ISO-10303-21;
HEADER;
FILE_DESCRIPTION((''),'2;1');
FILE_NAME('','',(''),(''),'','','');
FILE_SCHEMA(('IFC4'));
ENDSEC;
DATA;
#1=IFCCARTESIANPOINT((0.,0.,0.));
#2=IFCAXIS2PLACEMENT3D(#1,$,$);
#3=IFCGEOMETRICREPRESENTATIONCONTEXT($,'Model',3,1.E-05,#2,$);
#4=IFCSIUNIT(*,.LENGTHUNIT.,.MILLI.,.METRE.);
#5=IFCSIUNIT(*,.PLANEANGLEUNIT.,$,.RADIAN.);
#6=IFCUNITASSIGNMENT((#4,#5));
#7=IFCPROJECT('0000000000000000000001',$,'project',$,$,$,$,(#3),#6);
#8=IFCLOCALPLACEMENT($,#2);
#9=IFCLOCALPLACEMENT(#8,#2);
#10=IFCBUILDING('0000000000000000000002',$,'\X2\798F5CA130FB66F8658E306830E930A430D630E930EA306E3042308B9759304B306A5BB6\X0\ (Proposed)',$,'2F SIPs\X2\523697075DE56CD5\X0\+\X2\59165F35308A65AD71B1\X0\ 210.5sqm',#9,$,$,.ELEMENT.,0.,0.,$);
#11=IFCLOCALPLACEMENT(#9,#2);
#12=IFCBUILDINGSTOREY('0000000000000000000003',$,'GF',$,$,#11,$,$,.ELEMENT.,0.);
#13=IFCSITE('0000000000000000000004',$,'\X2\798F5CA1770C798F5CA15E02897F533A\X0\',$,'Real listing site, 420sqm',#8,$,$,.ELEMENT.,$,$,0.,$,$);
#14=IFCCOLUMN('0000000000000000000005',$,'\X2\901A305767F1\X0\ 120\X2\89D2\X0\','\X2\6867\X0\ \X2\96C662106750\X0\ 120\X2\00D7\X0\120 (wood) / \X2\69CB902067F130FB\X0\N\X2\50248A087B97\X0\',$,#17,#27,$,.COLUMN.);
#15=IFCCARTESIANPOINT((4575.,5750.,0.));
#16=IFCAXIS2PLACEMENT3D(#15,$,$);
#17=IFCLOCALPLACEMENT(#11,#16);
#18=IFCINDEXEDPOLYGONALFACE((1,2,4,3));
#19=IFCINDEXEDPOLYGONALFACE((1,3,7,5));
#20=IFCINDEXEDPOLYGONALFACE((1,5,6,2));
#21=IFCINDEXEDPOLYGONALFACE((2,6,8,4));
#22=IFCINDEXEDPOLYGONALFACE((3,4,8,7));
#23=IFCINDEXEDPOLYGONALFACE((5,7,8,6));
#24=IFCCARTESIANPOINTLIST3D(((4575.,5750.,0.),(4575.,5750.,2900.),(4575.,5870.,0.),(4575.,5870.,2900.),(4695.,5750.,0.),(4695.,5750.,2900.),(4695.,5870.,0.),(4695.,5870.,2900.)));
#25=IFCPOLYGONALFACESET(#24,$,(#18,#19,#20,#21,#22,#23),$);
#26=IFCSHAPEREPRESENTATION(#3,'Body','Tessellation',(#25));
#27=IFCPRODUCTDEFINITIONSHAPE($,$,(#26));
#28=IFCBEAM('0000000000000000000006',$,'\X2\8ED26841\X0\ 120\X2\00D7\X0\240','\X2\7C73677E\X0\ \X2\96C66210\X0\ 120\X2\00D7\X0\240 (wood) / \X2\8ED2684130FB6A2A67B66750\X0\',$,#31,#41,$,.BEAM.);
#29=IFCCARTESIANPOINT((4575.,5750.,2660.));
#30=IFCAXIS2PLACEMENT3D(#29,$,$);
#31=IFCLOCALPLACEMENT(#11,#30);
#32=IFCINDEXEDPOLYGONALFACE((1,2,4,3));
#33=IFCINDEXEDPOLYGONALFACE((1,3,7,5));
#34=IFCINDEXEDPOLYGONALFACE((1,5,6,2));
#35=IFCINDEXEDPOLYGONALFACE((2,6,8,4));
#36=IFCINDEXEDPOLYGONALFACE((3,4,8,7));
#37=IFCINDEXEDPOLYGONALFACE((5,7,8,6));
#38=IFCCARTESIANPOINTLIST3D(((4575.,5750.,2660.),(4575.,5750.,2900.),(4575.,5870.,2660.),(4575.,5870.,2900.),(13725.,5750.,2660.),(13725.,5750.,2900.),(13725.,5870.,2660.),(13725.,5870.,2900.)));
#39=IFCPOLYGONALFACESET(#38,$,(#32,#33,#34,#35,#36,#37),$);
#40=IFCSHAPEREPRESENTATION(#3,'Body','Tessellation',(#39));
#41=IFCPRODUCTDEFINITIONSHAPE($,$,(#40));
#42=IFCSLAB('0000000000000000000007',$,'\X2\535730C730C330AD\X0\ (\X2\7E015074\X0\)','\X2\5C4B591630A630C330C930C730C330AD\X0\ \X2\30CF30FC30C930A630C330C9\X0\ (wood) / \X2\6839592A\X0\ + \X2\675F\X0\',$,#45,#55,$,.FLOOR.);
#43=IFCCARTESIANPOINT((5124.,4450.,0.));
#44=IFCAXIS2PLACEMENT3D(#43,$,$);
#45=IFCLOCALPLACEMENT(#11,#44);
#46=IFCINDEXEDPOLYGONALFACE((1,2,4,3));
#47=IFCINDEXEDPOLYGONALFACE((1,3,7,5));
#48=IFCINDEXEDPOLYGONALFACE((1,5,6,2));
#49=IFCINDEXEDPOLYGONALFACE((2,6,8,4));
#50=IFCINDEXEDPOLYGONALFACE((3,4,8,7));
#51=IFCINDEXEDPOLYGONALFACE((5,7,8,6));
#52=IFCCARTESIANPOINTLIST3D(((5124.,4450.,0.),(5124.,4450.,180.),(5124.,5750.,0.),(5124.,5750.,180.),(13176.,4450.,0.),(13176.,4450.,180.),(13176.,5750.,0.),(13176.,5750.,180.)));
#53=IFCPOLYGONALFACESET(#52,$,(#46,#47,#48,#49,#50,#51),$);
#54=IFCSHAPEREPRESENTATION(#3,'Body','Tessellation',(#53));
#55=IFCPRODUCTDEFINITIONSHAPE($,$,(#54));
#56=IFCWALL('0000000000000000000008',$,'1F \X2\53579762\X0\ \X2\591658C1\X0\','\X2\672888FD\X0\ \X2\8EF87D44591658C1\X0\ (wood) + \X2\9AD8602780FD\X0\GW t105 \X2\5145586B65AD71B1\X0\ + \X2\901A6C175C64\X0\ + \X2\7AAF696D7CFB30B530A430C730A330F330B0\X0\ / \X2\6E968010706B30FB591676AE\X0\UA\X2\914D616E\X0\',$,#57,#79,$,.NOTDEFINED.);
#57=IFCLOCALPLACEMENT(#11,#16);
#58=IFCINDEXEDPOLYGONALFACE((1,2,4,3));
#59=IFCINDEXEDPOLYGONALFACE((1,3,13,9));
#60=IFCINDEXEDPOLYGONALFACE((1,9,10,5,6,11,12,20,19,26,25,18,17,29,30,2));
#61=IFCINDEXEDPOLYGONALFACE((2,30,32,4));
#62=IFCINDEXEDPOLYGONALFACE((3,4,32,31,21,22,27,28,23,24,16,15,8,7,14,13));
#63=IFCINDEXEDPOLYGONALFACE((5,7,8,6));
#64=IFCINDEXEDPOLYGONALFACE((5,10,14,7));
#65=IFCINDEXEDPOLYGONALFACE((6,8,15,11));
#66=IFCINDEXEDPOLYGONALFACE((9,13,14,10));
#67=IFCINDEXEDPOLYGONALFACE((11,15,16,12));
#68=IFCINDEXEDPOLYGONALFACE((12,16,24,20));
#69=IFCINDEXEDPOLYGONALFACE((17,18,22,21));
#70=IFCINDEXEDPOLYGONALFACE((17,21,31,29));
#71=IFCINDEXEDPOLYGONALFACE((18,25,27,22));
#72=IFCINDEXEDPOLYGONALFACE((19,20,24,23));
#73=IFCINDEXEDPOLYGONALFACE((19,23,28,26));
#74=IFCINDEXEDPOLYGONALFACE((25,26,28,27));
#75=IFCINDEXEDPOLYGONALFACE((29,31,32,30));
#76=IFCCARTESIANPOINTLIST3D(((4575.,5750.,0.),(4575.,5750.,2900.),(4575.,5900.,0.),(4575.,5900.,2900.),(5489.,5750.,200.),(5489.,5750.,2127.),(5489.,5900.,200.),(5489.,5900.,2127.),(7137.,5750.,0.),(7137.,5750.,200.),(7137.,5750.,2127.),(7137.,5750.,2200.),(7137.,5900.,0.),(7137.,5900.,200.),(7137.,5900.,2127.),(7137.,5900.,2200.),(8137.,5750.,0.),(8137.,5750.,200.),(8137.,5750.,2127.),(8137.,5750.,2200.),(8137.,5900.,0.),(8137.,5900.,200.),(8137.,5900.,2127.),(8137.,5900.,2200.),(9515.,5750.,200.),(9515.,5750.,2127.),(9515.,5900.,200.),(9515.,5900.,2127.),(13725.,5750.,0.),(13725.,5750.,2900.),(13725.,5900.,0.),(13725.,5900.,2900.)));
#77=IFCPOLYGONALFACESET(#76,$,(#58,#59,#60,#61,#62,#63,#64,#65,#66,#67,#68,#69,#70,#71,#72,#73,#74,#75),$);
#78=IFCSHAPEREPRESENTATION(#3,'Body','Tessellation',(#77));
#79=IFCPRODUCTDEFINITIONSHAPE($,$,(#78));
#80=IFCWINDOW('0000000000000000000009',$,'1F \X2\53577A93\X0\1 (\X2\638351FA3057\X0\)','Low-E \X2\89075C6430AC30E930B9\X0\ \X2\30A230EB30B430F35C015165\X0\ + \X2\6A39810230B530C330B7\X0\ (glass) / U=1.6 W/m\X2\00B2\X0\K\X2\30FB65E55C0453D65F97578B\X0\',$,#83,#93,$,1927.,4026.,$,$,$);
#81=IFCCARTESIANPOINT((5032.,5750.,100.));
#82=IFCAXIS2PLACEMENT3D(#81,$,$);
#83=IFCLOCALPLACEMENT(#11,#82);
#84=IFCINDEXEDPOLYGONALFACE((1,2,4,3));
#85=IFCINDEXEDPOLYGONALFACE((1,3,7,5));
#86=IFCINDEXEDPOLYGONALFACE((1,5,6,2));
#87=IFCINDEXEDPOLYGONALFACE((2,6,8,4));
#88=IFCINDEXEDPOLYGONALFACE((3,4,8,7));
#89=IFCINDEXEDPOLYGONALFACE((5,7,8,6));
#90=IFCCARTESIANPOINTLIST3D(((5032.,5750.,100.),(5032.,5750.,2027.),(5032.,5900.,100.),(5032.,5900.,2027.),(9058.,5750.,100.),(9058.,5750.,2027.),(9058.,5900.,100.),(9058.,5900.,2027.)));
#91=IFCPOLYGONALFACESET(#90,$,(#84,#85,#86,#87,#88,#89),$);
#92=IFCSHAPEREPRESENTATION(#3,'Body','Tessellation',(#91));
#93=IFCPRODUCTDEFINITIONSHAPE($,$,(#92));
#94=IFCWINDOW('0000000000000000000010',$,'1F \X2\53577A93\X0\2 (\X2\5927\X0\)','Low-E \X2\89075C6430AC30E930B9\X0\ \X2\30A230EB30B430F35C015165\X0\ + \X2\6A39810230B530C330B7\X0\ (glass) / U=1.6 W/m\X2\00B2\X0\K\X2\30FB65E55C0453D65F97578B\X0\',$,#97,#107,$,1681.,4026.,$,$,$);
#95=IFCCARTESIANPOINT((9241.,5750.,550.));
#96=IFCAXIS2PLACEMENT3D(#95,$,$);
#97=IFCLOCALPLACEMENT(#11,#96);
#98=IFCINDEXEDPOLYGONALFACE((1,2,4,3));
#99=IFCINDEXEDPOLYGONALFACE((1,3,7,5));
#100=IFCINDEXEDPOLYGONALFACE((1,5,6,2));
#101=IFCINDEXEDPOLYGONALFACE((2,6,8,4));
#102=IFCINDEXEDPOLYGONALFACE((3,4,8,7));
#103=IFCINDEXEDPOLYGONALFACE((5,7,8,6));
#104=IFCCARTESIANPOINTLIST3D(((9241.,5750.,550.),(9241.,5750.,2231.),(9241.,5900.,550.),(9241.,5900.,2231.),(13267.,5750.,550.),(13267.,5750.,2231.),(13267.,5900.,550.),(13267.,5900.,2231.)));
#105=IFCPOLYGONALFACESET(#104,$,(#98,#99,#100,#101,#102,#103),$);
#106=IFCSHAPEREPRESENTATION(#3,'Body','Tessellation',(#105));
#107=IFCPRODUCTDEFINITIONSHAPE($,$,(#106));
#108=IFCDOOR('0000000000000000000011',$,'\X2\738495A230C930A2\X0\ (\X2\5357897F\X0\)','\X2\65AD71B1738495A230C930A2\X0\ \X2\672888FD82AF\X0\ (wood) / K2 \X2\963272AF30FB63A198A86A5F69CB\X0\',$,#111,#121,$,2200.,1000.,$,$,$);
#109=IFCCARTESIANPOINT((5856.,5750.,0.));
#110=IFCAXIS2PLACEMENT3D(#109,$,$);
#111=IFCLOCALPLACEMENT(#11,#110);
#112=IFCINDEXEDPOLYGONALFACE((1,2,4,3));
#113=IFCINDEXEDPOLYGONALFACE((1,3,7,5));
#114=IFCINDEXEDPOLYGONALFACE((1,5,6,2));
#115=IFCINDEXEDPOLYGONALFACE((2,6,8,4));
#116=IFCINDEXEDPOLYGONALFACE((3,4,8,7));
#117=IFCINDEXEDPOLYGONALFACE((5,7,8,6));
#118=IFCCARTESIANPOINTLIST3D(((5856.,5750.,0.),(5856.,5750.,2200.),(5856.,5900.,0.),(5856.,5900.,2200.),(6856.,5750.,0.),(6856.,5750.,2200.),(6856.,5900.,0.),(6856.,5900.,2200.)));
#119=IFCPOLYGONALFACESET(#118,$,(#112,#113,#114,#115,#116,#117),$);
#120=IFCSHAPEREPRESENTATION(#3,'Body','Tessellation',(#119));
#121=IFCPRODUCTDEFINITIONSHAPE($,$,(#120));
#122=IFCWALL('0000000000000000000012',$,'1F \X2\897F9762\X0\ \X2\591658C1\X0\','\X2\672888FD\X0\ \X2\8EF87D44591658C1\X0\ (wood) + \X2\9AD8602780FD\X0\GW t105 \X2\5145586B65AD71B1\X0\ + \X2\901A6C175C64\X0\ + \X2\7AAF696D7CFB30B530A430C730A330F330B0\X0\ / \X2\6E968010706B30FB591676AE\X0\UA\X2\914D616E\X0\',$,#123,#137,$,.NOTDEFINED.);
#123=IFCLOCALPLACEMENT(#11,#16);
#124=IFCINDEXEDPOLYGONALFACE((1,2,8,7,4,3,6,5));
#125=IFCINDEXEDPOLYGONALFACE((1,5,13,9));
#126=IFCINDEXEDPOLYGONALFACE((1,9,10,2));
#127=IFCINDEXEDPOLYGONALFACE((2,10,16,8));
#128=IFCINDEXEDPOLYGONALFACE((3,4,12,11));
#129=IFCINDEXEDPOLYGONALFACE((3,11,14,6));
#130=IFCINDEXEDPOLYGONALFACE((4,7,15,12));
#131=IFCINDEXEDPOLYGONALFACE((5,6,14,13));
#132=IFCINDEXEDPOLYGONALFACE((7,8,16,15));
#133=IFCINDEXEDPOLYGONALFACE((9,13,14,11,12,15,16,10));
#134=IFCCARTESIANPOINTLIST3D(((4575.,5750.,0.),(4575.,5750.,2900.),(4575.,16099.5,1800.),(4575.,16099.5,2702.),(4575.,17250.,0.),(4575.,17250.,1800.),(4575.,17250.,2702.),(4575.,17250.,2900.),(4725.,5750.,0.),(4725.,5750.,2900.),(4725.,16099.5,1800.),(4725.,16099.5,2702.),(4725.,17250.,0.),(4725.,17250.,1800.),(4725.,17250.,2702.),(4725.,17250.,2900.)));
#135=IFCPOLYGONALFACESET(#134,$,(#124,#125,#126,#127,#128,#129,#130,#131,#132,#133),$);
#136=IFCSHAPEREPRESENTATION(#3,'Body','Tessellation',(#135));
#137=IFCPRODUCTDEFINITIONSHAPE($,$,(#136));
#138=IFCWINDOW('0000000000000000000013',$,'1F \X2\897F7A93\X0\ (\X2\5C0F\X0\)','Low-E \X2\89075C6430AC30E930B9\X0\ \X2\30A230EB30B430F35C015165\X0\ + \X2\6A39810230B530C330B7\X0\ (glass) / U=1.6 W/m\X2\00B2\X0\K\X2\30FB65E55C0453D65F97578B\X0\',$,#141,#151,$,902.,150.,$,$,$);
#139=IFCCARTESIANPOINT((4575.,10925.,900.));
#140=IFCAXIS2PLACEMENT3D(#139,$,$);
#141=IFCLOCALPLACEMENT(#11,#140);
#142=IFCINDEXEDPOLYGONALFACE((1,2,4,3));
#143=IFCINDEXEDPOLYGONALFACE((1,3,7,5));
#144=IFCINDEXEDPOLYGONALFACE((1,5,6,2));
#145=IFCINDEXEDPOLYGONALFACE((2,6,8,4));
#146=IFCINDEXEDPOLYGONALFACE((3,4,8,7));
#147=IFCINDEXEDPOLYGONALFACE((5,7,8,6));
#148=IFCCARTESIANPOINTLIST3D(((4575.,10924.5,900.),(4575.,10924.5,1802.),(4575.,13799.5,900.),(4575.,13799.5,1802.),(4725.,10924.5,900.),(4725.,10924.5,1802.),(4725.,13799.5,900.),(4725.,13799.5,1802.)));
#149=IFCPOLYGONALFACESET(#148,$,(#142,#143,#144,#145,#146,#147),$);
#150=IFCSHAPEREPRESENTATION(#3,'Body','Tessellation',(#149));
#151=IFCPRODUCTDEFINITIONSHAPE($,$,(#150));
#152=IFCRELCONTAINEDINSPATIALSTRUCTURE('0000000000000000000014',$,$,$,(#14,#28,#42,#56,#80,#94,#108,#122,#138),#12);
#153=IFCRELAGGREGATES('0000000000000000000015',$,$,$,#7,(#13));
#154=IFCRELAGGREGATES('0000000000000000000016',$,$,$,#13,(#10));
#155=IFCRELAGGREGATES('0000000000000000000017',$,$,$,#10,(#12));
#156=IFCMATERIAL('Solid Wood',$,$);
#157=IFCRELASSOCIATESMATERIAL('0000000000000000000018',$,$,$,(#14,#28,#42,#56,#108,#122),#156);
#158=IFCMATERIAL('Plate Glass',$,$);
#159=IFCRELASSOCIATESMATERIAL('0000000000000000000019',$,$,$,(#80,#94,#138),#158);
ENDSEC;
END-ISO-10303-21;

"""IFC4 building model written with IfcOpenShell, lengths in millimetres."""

from ifc_helpers import new_model, si_unit, frame, frame_2d, origin, place, context, project, spatial, rectangle, extrude, material, element, fill, save


model = new_model("IFC4")

# Units and contexts
model_context = context("Model", 3, precision=1e-05, world=origin())
ifc_project = project(units=[si_unit("LENGTHUNIT", "METRE", prefix="MILLI"), si_unit("PLANEANGLEUNIT", "RADIAN")], contexts=[model_context])

# Site, building, storey
site_placement = place(None, origin())
site = spatial("IfcSite", under=ifc_project, at=site_placement, Name="福岡県福岡市西区", ObjectType="Real listing site, 420sqm", CompositionType="ELEMENT", RefElevation=0.0)
building_placement = place(site_placement, origin())
building = spatial("IfcBuilding", under=site, at=building_placement, Name="福岡・書斎とライブラリのある静かな家 (Proposed)", ObjectType="2F SIPs制震工法+外張り断熱 210.5sqm", CompositionType="ELEMENT", ElevationOfRefHeight=0.0, ElevationOfTerrain=0.0)
storey_placement = place(building_placement, origin())
storey = spatial("IfcBuildingStorey", under=building, at=storey_placement, Name="GF", CompositionType="ELEMENT", Elevation=0.0)

# Column
ifc_material_1 = material(Name="Solid Wood")
column_placement = place(storey_placement, frame((4575.0, 5750.0, 0.0)))
element("IfcColumn", 1, at=column_placement, inside=storey, material=ifc_material_1, Name="通し柱 120角", Description="桧 集成材 120×120 (wood) / 構造柱・N値計算", PredefinedType="COLUMN", context=model_context, shape_type="SweptSolid", body=[
    extrude(rectangle(XDim=120.0, YDim=120.0, at=frame_2d((60.0, 60.0))), frame((4575.0, 5750.0, 0.0)), (0.0, 0.0, 1.0), 2900.0),
])

# Beam
beam_1_placement = place(storey_placement, frame((4575.0, 5750.0, 2660.0)))
element("IfcBeam", 2, at=beam_1_placement, inside=storey, material=ifc_material_1, Name="軒桁 120×240", Description="米松 集成 120×240 (wood) / 軒桁・横架材", PredefinedType="BEAM", context=model_context, shape_type="SweptSolid", body=[
    extrude(rectangle(XDim=9150.0, YDim=120.0, at=frame_2d((4575.0, 60.0))), frame((4575.0, 5750.0, 2660.0)), (0.0, 0.0, 1.0), 240.0),
])

# Slab
slab_1_placement = place(storey_placement, frame((5124.0, 4450.0, 0.0)))
element("IfcSlab", 3, at=slab_1_placement, inside=storey, material=ifc_material_1, Name="南デッキ (縁側)", Description="屋外ウッドデッキ ハードウッド (wood) / 根太 + 束", PredefinedType="FLOOR", context=model_context, shape_type="SweptSolid", body=[
    extrude(rectangle(XDim=8052.0, YDim=1300.0, at=frame_2d((4026.0, 650.0))), frame((5124.0, 4450.0, 0.0)), (0.0, 0.0, 1.0), 180.0),
])

# Wall, openings, windows, door
wall_1_placement = place(storey_placement, frame((4575.0, 5750.0, 0.0)))
wall_1 = element("IfcWall", 4, at=wall_1_placement, inside=storey, material=ifc_material_1, Name="1F 南面 外壁", Description="木製 軸組外壁 (wood) + 高性能GW t105 充填断熱 + 通気層 + 窯業系サイディング / 準耐火・外皮UA配慮", PredefinedType="NOTDEFINED", context=model_context, shape_type="SweptSolid", body=[
    extrude(rectangle(XDim=9150.0, YDim=150.0, at=frame_2d((4575.0, 75.0))), frame((4575.0, 5750.0, 0.0)), (0.0, 0.0, 1.0), 2900.0),
])
opening_1_placement = place(storey_placement, frame((5032.0, 5750.0, 100.0)))
opening_1 = element("IfcOpeningElement", 5, at=opening_1_placement, cuts=wall_1, PredefinedType="NOTDEFINED", context=model_context, shape_type="SweptSolid", body=[
    extrude(rectangle(XDim=4026.0, YDim=150.0, at=frame_2d((2013.0, 75.0))), frame((5032.0, 5750.0, 100.0)), (0.0, 0.0, 1.0), 1927.0),
])
opening_2_placement = place(storey_placement, frame((9241.0, 5750.0, 550.0)))
opening_2 = element("IfcOpeningElement", 6, at=opening_2_placement, cuts=wall_1, PredefinedType="NOTDEFINED", context=model_context, shape_type="SweptSolid", body=[
    extrude(rectangle(XDim=4026.0, YDim=150.0, at=frame_2d((2013.0, 75.0))), frame((9241.0, 5750.0, 550.0)), (0.0, 0.0, 1.0), 1681.0),
])
opening_3_placement = place(storey_placement, frame((5856.0, 5750.0, 0.0)))
opening_3 = element("IfcOpeningElement", 7, at=opening_3_placement, cuts=wall_1, PredefinedType="NOTDEFINED", context=model_context, shape_type="SweptSolid", body=[
    extrude(rectangle(XDim=1000.0, YDim=150.0, at=frame_2d((500.0, 75.0))), frame((5856.0, 5750.0, 0.0)), (0.0, 0.0, 1.0), 2200.0),
])
ifc_material_2 = material(Name="Plate Glass")
window_1_placement = place(storey_placement, frame((5032.0, 5750.0, 100.0)))
window_1 = element("IfcWindow", 8, at=window_1_placement, inside=storey, material=ifc_material_2, Name="1F 南窓1 (掃出し)", Description="Low-E 複層ガラス アルゴン封入 + 樹脂サッシ (glass) / U=1.6 W/m²K・日射取得型", OverallHeight=1927.0, OverallWidth=4026.0, context=model_context, shape_type="SweptSolid", body=[
    extrude(rectangle(XDim=4026.0, YDim=150.0, at=frame_2d((2013.0, 75.0))), frame((5032.0, 5750.0, 100.0)), (0.0, 0.0, 1.0), 1927.0),
])
fill(opening_1, window_1)
window_2_placement = place(storey_placement, frame((9241.0, 5750.0, 550.0)))
window_2 = element("IfcWindow", 9, at=window_2_placement, inside=storey, material=ifc_material_2, Name="1F 南窓2 (大)", Description="Low-E 複層ガラス アルゴン封入 + 樹脂サッシ (glass) / U=1.6 W/m²K・日射取得型", OverallHeight=1681.0, OverallWidth=4026.0, context=model_context, shape_type="SweptSolid", body=[
    extrude(rectangle(XDim=4026.0, YDim=150.0, at=frame_2d((2013.0, 75.0))), frame((9241.0, 5750.0, 550.0)), (0.0, 0.0, 1.0), 1681.0),
])
fill(opening_2, window_2)
door_placement = place(storey_placement, frame((5856.0, 5750.0, 0.0)))
door = element("IfcDoor", 10, at=door_placement, inside=storey, material=ifc_material_1, Name="玄関ドア (南西)", Description="断熱玄関ドア 木製芯 (wood) / K2 防犯・採風機構", OverallHeight=2200.0, OverallWidth=1000.0, context=model_context, shape_type="SweptSolid", body=[
    extrude(rectangle(XDim=1000.0, YDim=150.0, at=frame_2d((500.0, 75.0))), frame((5856.0, 5750.0, 0.0)), (0.0, 0.0, 1.0), 2200.0),
])
fill(opening_3, door)

# Wall, opening, window
wall_2_placement = place(storey_placement, frame((4575.0, 5750.0, 0.0)))
wall_2 = element("IfcWall", 11, at=wall_2_placement, inside=storey, material=ifc_material_1, Name="1F 西面 外壁", Description="木製 軸組外壁 (wood) + 高性能GW t105 充填断熱 + 通気層 + 窯業系サイディング / 準耐火・外皮UA配慮", PredefinedType="NOTDEFINED", context=model_context, shape_type="SweptSolid", body=[
    extrude(rectangle(XDim=150.0, YDim=11500.0, at=frame_2d((75.0, 5750.0))), frame((4575.0, 5750.0, 0.0)), (0.0, 0.0, 1.0), 2900.0),
])
opening_4_placement = place(storey_placement, frame((4575.0, 10925.0, 900.0)))
opening_4 = element("IfcOpeningElement", 12, at=opening_4_placement, cuts=wall_2, PredefinedType="NOTDEFINED", context=model_context, shape_type="SweptSolid", body=[
    extrude(rectangle(XDim=150.0, YDim=2875.0, at=frame_2d((75.0, 1437.0))), frame((4575.0, 10925.0, 900.0)), (0.0, 0.0, 1.0), 902.0),
])
window_3_placement = place(storey_placement, frame((4575.0, 10925.0, 900.0)))
window_3 = element("IfcWindow", 13, at=window_3_placement, inside=storey, material=ifc_material_2, Name="1F 西窓 (小)", Description="Low-E 複層ガラス アルゴン封入 + 樹脂サッシ (glass) / U=1.6 W/m²K・日射取得型", OverallHeight=902.0, OverallWidth=150.0, context=model_context, shape_type="SweptSolid", body=[
    extrude(rectangle(XDim=150.0, YDim=2875.0, at=frame_2d((75.0, 1437.0))), frame((4575.0, 10925.0, 900.0)), (0.0, 0.0, 1.0), 902.0),
])
fill(opening_4, window_3)

save(model, "model.ifc")
